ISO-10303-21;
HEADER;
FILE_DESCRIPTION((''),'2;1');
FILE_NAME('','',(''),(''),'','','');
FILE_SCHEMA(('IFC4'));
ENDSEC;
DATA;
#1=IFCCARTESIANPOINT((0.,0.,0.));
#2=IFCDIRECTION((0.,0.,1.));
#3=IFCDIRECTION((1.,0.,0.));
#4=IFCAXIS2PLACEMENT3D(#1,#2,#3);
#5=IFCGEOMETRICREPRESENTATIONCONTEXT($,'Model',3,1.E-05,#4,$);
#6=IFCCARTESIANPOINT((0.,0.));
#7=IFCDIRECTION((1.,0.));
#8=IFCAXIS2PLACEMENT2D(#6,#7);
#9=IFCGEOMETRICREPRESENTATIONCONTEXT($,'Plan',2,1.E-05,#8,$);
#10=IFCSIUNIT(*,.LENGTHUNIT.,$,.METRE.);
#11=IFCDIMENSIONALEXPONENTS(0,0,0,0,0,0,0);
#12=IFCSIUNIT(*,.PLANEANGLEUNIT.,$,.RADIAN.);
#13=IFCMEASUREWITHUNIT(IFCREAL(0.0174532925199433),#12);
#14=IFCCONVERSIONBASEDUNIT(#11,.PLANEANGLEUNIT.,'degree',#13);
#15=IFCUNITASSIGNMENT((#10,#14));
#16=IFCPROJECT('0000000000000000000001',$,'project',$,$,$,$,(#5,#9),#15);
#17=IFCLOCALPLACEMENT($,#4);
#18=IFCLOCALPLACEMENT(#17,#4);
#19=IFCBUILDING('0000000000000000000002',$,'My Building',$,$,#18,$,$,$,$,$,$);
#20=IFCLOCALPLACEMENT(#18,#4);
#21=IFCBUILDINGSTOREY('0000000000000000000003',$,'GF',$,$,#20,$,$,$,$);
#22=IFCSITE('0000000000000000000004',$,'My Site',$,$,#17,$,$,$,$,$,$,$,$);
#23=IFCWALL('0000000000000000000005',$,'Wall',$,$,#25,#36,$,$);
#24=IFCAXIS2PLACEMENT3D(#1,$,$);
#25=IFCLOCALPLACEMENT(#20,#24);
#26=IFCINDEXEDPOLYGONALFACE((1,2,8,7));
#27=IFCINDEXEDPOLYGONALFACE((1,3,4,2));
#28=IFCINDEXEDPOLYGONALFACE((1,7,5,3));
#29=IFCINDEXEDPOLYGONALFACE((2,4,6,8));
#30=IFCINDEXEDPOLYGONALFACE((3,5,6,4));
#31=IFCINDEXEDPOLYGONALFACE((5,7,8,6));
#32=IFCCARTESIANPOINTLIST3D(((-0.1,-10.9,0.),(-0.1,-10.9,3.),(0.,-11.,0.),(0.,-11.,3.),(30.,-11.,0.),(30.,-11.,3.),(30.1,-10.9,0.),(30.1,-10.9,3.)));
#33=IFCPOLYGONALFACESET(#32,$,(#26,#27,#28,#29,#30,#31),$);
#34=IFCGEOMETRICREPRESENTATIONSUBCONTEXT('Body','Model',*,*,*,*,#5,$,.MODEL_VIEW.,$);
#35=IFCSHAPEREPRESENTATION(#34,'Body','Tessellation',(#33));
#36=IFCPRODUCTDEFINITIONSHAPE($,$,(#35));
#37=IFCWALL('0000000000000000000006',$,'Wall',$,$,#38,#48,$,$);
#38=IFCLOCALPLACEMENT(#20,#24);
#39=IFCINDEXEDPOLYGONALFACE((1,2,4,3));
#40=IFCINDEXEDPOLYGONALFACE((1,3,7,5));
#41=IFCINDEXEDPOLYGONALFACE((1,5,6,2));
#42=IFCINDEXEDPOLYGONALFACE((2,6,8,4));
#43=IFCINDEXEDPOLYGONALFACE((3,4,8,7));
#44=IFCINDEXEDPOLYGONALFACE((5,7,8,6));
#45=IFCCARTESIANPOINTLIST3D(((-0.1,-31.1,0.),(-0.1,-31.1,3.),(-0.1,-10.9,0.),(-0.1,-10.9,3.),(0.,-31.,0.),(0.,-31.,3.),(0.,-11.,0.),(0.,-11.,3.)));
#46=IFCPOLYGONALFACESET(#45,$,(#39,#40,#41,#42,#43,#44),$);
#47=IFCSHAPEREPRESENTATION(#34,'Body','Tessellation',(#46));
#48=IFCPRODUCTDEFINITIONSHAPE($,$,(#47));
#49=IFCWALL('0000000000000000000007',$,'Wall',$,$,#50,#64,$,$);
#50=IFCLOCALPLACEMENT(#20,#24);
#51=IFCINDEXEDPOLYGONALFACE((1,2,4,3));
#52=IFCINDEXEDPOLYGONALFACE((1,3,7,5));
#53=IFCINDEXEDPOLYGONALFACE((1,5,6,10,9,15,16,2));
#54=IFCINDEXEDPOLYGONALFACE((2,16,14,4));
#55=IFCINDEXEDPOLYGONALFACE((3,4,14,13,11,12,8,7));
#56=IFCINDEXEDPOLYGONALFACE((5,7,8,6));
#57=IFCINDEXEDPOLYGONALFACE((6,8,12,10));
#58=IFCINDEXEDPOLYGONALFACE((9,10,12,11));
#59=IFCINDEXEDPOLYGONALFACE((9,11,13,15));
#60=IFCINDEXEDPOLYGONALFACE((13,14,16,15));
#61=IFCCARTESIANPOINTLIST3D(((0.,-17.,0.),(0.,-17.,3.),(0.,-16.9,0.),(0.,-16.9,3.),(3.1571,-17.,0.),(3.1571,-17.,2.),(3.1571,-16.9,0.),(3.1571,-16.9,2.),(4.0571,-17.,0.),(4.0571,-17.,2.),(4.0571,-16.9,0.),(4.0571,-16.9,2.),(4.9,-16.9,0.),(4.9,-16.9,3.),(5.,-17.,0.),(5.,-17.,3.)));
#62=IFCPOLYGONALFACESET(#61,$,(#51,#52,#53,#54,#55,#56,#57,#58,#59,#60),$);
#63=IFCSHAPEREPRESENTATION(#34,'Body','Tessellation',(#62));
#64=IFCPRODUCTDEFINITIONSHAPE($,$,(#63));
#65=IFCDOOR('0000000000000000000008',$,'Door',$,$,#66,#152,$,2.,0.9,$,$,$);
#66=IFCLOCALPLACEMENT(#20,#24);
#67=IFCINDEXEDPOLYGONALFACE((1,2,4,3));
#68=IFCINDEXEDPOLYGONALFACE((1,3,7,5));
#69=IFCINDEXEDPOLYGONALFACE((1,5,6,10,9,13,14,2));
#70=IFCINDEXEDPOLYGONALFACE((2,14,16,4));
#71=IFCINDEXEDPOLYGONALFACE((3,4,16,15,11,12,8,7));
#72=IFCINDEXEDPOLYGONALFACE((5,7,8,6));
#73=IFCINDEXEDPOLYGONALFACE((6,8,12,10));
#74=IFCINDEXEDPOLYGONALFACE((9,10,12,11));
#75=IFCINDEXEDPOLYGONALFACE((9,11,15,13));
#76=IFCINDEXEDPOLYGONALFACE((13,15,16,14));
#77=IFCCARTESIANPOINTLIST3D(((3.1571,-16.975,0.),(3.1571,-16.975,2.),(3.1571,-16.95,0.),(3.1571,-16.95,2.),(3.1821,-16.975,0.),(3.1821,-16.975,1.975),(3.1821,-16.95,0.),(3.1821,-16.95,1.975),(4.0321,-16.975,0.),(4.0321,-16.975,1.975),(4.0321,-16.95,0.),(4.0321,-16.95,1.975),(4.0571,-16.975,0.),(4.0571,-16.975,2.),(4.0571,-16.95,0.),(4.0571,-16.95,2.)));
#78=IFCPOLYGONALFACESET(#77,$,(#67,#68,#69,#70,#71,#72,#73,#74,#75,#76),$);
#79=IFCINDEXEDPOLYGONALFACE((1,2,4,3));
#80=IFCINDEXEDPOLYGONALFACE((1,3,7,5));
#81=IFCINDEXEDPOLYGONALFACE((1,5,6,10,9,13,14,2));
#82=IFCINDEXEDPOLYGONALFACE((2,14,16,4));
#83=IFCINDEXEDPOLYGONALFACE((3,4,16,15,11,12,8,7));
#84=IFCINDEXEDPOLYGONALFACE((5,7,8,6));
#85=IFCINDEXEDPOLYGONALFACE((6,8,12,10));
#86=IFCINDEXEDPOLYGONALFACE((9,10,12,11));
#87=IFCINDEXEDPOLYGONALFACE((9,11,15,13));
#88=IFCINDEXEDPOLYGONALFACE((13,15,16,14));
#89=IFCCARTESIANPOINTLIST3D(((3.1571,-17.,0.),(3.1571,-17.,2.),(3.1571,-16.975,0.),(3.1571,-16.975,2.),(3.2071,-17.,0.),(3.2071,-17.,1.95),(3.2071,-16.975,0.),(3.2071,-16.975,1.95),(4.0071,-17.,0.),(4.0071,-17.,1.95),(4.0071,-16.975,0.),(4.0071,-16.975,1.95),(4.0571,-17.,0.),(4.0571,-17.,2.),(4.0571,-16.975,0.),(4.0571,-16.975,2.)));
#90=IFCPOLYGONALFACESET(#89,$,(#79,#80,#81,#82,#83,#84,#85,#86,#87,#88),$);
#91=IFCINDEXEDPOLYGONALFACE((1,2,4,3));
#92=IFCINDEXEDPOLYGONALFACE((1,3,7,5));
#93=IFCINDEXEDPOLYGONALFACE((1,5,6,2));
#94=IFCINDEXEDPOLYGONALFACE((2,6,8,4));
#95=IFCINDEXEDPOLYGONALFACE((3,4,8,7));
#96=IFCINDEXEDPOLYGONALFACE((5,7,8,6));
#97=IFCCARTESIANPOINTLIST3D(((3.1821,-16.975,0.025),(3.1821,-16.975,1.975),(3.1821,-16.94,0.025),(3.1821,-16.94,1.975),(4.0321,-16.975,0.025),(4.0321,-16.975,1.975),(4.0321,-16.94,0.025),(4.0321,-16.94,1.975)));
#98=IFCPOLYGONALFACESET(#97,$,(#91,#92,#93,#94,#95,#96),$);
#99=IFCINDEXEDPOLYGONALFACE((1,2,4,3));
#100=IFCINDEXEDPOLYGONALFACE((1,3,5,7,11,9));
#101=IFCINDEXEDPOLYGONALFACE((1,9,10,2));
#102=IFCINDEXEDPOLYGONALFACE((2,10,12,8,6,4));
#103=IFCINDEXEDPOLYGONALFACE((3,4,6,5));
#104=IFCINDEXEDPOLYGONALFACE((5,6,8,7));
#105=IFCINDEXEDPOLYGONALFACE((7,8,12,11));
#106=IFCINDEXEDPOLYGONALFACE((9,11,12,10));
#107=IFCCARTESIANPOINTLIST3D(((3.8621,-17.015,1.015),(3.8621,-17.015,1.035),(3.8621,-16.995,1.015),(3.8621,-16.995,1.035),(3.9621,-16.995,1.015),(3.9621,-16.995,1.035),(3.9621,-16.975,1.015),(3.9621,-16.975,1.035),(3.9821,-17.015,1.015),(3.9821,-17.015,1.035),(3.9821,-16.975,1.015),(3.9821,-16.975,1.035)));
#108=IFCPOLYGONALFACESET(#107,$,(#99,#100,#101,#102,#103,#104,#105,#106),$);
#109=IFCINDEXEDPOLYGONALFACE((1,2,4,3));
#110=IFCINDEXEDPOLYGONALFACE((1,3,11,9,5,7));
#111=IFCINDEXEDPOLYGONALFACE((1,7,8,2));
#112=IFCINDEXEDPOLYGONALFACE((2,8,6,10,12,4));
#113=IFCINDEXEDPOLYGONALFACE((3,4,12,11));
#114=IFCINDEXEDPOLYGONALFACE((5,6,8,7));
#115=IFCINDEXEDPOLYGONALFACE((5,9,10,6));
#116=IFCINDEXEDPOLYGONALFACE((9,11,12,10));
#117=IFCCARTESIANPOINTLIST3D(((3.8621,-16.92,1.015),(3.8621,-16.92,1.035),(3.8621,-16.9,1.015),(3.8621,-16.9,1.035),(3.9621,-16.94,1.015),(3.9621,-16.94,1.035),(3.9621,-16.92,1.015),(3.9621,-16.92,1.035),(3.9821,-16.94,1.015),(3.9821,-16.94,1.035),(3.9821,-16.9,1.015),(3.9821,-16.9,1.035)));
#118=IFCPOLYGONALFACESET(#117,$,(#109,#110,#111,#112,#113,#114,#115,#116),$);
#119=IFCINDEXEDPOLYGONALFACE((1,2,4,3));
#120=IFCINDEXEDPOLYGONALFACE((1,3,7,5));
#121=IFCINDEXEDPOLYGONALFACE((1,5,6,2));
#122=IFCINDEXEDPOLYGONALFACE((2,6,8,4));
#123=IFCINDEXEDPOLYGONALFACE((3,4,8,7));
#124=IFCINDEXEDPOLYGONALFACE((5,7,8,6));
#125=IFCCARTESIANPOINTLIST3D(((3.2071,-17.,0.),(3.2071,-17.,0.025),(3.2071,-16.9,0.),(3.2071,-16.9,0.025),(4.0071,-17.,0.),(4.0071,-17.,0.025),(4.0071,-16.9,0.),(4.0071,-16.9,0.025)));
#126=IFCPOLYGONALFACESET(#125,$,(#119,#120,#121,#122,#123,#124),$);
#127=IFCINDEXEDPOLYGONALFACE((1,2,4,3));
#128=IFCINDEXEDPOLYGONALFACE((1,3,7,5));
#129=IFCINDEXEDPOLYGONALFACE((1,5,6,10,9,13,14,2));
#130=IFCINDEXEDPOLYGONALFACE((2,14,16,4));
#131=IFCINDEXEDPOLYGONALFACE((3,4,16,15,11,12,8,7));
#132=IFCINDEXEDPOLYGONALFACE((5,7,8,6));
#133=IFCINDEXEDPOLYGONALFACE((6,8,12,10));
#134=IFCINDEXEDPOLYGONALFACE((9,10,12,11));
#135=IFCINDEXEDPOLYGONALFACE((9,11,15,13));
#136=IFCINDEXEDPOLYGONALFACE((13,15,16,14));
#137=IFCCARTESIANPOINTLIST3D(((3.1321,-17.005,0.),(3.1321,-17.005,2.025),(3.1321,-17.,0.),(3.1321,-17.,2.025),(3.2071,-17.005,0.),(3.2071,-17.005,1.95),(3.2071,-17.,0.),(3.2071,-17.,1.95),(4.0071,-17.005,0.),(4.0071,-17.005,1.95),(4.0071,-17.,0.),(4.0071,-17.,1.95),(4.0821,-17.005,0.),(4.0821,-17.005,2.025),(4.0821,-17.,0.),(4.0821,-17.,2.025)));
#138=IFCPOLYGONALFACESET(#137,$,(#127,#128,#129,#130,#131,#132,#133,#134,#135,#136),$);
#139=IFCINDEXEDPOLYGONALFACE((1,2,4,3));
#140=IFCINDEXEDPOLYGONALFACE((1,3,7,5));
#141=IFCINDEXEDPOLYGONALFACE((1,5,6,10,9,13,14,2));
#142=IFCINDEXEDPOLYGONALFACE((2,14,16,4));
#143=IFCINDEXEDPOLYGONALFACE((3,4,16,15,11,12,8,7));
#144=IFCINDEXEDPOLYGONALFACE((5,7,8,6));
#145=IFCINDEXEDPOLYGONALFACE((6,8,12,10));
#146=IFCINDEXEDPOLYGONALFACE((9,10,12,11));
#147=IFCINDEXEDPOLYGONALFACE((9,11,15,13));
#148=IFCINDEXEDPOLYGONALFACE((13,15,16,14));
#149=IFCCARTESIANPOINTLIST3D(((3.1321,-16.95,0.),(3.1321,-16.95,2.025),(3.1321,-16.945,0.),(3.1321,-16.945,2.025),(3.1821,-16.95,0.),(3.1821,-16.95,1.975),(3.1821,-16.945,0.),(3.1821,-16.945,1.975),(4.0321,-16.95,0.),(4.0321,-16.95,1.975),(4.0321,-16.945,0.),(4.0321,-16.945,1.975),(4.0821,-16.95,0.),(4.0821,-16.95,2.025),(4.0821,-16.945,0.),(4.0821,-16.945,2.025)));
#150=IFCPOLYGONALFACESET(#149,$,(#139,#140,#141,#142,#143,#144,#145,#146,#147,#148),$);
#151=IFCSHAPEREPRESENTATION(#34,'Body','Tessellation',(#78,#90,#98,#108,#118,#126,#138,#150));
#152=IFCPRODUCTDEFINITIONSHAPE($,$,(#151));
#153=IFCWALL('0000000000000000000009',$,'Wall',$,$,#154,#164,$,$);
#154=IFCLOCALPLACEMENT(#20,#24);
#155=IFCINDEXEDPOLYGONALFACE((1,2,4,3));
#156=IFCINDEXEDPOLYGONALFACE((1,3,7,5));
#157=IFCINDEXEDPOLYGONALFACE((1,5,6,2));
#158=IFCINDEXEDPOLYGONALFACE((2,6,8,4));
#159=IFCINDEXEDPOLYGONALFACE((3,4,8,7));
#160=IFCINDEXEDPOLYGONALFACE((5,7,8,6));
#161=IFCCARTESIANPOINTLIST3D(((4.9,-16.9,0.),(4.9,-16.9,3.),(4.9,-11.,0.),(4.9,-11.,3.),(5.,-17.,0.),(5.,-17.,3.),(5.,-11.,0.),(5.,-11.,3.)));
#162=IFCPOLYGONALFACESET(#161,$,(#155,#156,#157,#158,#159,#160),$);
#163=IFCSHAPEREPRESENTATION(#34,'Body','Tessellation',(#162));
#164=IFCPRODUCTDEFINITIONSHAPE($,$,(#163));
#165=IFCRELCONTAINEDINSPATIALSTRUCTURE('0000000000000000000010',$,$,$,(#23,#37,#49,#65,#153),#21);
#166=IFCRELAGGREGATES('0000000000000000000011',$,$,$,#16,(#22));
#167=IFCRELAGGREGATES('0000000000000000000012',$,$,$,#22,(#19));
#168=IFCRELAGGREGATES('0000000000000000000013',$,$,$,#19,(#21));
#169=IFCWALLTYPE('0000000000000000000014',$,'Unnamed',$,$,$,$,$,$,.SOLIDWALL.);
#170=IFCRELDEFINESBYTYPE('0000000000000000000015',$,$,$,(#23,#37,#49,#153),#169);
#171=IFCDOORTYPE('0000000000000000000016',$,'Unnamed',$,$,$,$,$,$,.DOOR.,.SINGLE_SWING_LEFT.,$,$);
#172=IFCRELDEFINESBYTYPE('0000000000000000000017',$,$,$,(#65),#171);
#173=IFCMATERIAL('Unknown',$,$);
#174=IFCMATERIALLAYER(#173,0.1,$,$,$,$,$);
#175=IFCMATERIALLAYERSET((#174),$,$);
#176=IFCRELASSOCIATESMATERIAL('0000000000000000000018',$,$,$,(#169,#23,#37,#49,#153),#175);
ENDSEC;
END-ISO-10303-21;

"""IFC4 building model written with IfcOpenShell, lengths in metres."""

from ifc_helpers import new_model, entity, si_unit, converted_unit, frame, origin_with_axes, origin_2d_with_axis, place, context, subcontext, project, spatial, line, indexed_curve, outline, extrude, shape, source, transform, mapped, material, layer, layer_set, layer_usage, type_object, type_shapes, element, fill, save


model = new_model("IFC4")

# Units and contexts
model_context = context("Model", 3, precision=1e-05, world=origin_with_axes())
plan_context = context("Plan", 2, precision=1e-05, world=origin_2d_with_axis())
body_context_1 = subcontext(model_context, "Body", "Model", "MODEL_VIEW")
body_context_2 = subcontext(plan_context, "Body", "Plan", "PLAN_VIEW")
ifc_project = project(units=[si_unit("LENGTHUNIT", "METRE"), converted_unit("PLANEANGLEUNIT", "degree", entity("IfcReal", 0.0174532925199433), si_unit("PLANEANGLEUNIT", "RADIAN"), dimensions=[0, 0, 0, 0, 0, 0, 0])], contexts=[model_context, plan_context])

# Site, building, storey
site_placement = place(None, origin_with_axes())
site = spatial("IfcSite", under=ifc_project, at=site_placement, Name="My Site")
building_placement = place(site_placement, origin_with_axes())
building = spatial("IfcBuilding", under=site, at=building_placement, Name="My Building")
storey_placement = place(building_placement, origin_with_axes())
storey = spatial("IfcBuildingStorey", under=building, at=storey_placement, Name="GF")

# Walls
ifc_material = material(Name="Unknown")
ifc_layer = layer(ifc_material, 0.1)
ifc_layer_set = layer_set([ifc_layer])
ifc_layer_usage_1 = layer_usage(ifc_layer_set, "AXIS2", "POSITIVE", 0.0)
wall_type = type_object("IfcWallType", Name="Unnamed", PredefinedType="SOLIDWALL", material=ifc_layer_set)
wall_1_placement = place(storey_placement, frame((0.0, -11.0, 0.0), z_axis=(0.0, 0.0, 1.0), x_axis=(1.0, 0.0, 0.0)))
element("IfcWall", 1, at=wall_1_placement, inside=storey, type_object=wall_type, material=ifc_layer_usage_1, Name="Wall", context=body_context_1, shape_type="SweptSolid", body=[
    extrude(outline(indexed_curve([(0.0, 0.0), (-0.1, 0.1), (30.1, 0.1), (30.0, 0.0)], segments=[line(1, 2, 3, 4, 1)])), origin_with_axes(), (0.0, 0.0, 1.0), 3.0),
])
ifc_layer_usage_2 = layer_usage(ifc_layer_set, "AXIS2", "POSITIVE", 0.0)
wall_2_placement = place(storey_placement, frame((0.0, -31.0, 0.0), z_axis=(0.0, 0.0, 1.0), x_axis=(0.0, 1.0, 0.0)))
element("IfcWall", 2, at=wall_2_placement, inside=storey, type_object=wall_type, material=ifc_layer_usage_2, Name="Wall", context=body_context_1, shape_type="SweptSolid", body=[
    extrude(outline(indexed_curve([(0.0, 0.0), (-0.1, 0.1), (20.1, 0.1), (20.0, 0.0)], segments=[line(1, 2, 3, 4, 1)])), origin_with_axes(), (0.0, 0.0, 1.0), 3.0),
])

# Wall, opening, door
ifc_layer_usage_3 = layer_usage(ifc_layer_set, "AXIS2", "POSITIVE", 0.0)
wall_3_placement = place(storey_placement, frame((0.0, -17.0, 0.0), z_axis=(0.0, 0.0, 1.0), x_axis=(1.0, 0.0, 0.0)))
wall_3 = element("IfcWall", 3, at=wall_3_placement, inside=storey, type_object=wall_type, material=ifc_layer_usage_3, Name="Wall", context=body_context_1, shape_type="SweptSolid", body=[
    extrude(outline(indexed_curve([(0.0, 0.0), (0.0, 0.1), (4.9, 0.1), (5.0, 0.0)], segments=[line(1, 2, 3, 4, 1)])), origin_with_axes(), (0.0, 0.0, 1.0), 3.0),
])
shared_shape_1 = source(origin_with_axes(), body_context_1, "Body", "SweptSolid", [
    extrude(outline(indexed_curve([(0.0, 0.0), (0.9, 0.0), (0.9, 2.0), (0.0, 2.0)], segments=[line(1, 2, 3, 4, 1)])), frame((0.0, -0.6, 0.0), z_axis=(0.0, -1.0, 0.0), x_axis=(1.0, 0.0, 0.0)), (0.0, 0.0, -1.0), 1.2),
])
opening_1_placement = place(wall_3_placement, frame((3.1571, 0.0, 0.0), z_axis=(0.0, 0.0, 1.0), x_axis=(1.0, 0.0, 0.0)))
opening_1 = element("IfcOpeningElement", 4, at=opening_1_placement, cuts=wall_3, PredefinedType="OPENING", context=body_context_1, shape_type="MappedRepresentation", body=[
    mapped(shared_shape_1, transform((0.0, 0.0, 0.0), x_axis=(1.0, 0.0, 0.0), y_axis=(0.0, 1.0, 0.0), z_axis=(0.0, 0.0, 1.0), scale=1.0)),
])
door_type = type_object("IfcDoorType", Name="Unnamed", OperationType="SINGLE_SWING_LEFT", PredefinedType="DOOR")
shared_shape_2 = source(origin_with_axes(), body_context_1, "Body", "SweptSolid", [
    extrude(outline(indexed_curve([(0.0, 0.0), (0.0, 2.0), (0.9, 2.0), (0.9, 0.0), (0.875, 0.0), (0.875, 1.975), (0.025, 1.975), (0.025, 0.0)], segments=[line(1, 2, 3, 4, 5, 6, 7, 8, 1)])), frame((0.0, 0.025, 0.0), z_axis=(0.0, -1.0, 0.0), x_axis=(1.0, 0.0, 0.0)), (0.0, 0.0, -1.0), 0.025),
    extrude(outline(indexed_curve([(0.0, 0.0), (0.0, 2.0), (0.9, 2.0), (0.9, 0.0), (0.85, 0.0), (0.85, 1.95), (0.05, 1.95), (0.05, 0.0)], segments=[line(1, 2, 3, 4, 5, 6, 7, 8, 1)])), frame((0.0, 0.0, 0.0), z_axis=(0.0, -1.0, 0.0), x_axis=(1.0, 0.0, 0.0)), (0.0, 0.0, -1.0), 0.025),
    extrude(outline(indexed_curve([(0.0, 0.0), (0.85, 0.0), (0.85, 0.035), (0.0, 0.035)], segments=[line(1, 2, 3, 4, 1)])), frame((0.025, 0.025, 0.025), z_axis=(0.0, 0.0, 1.0), x_axis=(1.0, 0.0, 0.0)), (0.0, 0.0, 1.0), 1.95),
    extrude(outline(indexed_curve([(0.0, 0.0), (0.0, -0.04), (-0.12, -0.04), (-0.12, -0.02), (-0.02, -0.02), (-0.02, 0.0)], segments=[line(1, 2, 3, 4, 5, 6, 1)])), frame((0.825, 0.025, 1.015), z_axis=(0.0, 0.0, 1.0), x_axis=(1.0, 0.0, 0.0)), (0.0, 0.0, 1.0), 0.02),
    extrude(outline(indexed_curve([(0.0, 0.0), (0.0, 0.04), (-0.12, 0.04), (-0.12, 0.02), (-0.02, 0.02), (-0.02, 0.0)], segments=[line(1, 2, 3, 4, 5, 6, 1)])), frame((0.825, 0.06, 1.015), z_axis=(0.0, 0.0, 1.0), x_axis=(1.0, 0.0, 0.0)), (0.0, 0.0, 1.0), 0.02),
    extrude(outline(indexed_curve([(0.0, 0.0), (0.8, 0.0), (0.8, 0.1), (0.0, 0.1)], segments=[line(1, 2, 3, 4, 1)])), frame((0.05, 0.0, 0.0), z_axis=(0.0, 0.0, 1.0), x_axis=(1.0, 0.0, 0.0)), (0.0, 0.0, 1.0), 0.025),
    extrude(outline(indexed_curve([(0.0, 0.0), (0.0, 2.025), (0.95, 2.025), (0.95, 0.0), (0.875, 0.0), (0.875, 1.95), (0.075, 1.95), (0.075, 0.0)], segments=[line(1, 2, 3, 4, 5, 6, 7, 8, 1)])), frame((-0.025, -0.005, 0.0), z_axis=(0.0, -1.0, 0.0), x_axis=(1.0, 0.0, 0.0)), (0.0, 0.0, -1.0), 0.005),
    extrude(outline(indexed_curve([(0.0, 0.0), (0.0, 2.025), (0.95, 2.025), (0.95, 0.0), (0.9, 0.0), (0.9, 1.975), (0.05, 1.975), (0.05, 0.0)], segments=[line(1, 2, 3, 4, 5, 6, 7, 8, 1)])), frame((-0.025, 0.05, 0.0), z_axis=(0.0, -1.0, 0.0), x_axis=(1.0, 0.0, 0.0)), (0.0, 0.0, -1.0), 0.005),
])
shared_shape_3 = source(origin_with_axes(), body_context_2, "Body", "Curve2D", [
    entity("IfcIndexedPolyCurve", entity("IfcCartesianPointList2D", [[0.0, 0.0], [0.0, 0.05], [0.025, 0.05], [0.025, 0.025], [0.05, 0.025], [0.05, 0.0]]), [entity("IfcLineIndex", [1, 2, 3, 4, 5, 6, 1])]),
    entity("IfcIndexedPolyCurve", entity("IfcCartesianPointList2D", [[0.9, 0.0], [0.9, 0.05], [0.875, 0.05], [0.875, 0.025], [0.85, 0.025], [0.85, 0.0]]), [entity("IfcLineIndex", [1, 2, 3, 4, 5, 6, 1])]),
    entity("IfcTrimmedCurve", entity("IfcEllipse", entity("IfcAxis2Placement2D", entity("IfcCartesianPoint", [0.06, 0.05]), entity("IfcDirection", [1.0, 0.0])), 0.815, 0.85), [entity("IfcCartesianPoint", [0.875, 0.05])], [entity("IfcCartesianPoint", [0.06, 0.9])], True, "CARTESIAN"),
    entity("IfcIndexedPolyCurve", entity("IfcCartesianPointList2D", [[0.025, 0.05], [0.06, 0.05], [0.06, 0.9], [0.025, 0.9]]), [entity("IfcLineIndex", [1, 2, 3, 4, 1])]),
])
type_shapes(door_type, [shared_shape_2, shared_shape_3])
door_1_placement = place(opening_1_placement, origin_with_axes())
door_1 = element("IfcDoor", 5, at=door_1_placement, inside=storey, type_object=door_type, Name="Door", OverallHeight=2.0, OverallWidth=0.9, shapes=[
    shape(body_context_1, "Body", "MappedRepresentation", [mapped(shared_shape_2, transform((0.0, 0.0, 0.0), x_axis=(1.0, 0.0, 0.0), y_axis=(0.0, 1.0, 0.0), z_axis=(0.0, 0.0, 1.0), scale=1.0))]),
    shape(body_context_2, "Body", "MappedRepresentation", [mapped(shared_shape_3, transform((0.0, 0.0, 0.0), x_axis=(1.0, 0.0, 0.0), y_axis=(0.0, 1.0, 0.0), z_axis=(0.0, 0.0, 1.0), scale=1.0))]),
])
fill(opening_1, door_1)

# Wall
ifc_layer_usage_4 = layer_usage(ifc_layer_set, "AXIS2", "POSITIVE", 0.0)
wall_4_placement = place(storey_placement, frame((5.0, -17.0, 0.0), z_axis=(0.0, 0.0, 1.0), x_axis=(0.0, 1.0, 0.0)))
element("IfcWall", 6, at=wall_4_placement, inside=storey, type_object=wall_type, material=ifc_layer_usage_4, Name="Wall", context=body_context_1, shape_type="SweptSolid", body=[
    extrude(outline(indexed_curve([(0.0, 0.0), (0.1, 0.1), (6.0, 0.1), (6.0, 0.0)], segments=[line(1, 2, 3, 4, 1)])), origin_with_axes(), (0.0, 0.0, 1.0), 3.0),
])

save(model, "model.ifc")
